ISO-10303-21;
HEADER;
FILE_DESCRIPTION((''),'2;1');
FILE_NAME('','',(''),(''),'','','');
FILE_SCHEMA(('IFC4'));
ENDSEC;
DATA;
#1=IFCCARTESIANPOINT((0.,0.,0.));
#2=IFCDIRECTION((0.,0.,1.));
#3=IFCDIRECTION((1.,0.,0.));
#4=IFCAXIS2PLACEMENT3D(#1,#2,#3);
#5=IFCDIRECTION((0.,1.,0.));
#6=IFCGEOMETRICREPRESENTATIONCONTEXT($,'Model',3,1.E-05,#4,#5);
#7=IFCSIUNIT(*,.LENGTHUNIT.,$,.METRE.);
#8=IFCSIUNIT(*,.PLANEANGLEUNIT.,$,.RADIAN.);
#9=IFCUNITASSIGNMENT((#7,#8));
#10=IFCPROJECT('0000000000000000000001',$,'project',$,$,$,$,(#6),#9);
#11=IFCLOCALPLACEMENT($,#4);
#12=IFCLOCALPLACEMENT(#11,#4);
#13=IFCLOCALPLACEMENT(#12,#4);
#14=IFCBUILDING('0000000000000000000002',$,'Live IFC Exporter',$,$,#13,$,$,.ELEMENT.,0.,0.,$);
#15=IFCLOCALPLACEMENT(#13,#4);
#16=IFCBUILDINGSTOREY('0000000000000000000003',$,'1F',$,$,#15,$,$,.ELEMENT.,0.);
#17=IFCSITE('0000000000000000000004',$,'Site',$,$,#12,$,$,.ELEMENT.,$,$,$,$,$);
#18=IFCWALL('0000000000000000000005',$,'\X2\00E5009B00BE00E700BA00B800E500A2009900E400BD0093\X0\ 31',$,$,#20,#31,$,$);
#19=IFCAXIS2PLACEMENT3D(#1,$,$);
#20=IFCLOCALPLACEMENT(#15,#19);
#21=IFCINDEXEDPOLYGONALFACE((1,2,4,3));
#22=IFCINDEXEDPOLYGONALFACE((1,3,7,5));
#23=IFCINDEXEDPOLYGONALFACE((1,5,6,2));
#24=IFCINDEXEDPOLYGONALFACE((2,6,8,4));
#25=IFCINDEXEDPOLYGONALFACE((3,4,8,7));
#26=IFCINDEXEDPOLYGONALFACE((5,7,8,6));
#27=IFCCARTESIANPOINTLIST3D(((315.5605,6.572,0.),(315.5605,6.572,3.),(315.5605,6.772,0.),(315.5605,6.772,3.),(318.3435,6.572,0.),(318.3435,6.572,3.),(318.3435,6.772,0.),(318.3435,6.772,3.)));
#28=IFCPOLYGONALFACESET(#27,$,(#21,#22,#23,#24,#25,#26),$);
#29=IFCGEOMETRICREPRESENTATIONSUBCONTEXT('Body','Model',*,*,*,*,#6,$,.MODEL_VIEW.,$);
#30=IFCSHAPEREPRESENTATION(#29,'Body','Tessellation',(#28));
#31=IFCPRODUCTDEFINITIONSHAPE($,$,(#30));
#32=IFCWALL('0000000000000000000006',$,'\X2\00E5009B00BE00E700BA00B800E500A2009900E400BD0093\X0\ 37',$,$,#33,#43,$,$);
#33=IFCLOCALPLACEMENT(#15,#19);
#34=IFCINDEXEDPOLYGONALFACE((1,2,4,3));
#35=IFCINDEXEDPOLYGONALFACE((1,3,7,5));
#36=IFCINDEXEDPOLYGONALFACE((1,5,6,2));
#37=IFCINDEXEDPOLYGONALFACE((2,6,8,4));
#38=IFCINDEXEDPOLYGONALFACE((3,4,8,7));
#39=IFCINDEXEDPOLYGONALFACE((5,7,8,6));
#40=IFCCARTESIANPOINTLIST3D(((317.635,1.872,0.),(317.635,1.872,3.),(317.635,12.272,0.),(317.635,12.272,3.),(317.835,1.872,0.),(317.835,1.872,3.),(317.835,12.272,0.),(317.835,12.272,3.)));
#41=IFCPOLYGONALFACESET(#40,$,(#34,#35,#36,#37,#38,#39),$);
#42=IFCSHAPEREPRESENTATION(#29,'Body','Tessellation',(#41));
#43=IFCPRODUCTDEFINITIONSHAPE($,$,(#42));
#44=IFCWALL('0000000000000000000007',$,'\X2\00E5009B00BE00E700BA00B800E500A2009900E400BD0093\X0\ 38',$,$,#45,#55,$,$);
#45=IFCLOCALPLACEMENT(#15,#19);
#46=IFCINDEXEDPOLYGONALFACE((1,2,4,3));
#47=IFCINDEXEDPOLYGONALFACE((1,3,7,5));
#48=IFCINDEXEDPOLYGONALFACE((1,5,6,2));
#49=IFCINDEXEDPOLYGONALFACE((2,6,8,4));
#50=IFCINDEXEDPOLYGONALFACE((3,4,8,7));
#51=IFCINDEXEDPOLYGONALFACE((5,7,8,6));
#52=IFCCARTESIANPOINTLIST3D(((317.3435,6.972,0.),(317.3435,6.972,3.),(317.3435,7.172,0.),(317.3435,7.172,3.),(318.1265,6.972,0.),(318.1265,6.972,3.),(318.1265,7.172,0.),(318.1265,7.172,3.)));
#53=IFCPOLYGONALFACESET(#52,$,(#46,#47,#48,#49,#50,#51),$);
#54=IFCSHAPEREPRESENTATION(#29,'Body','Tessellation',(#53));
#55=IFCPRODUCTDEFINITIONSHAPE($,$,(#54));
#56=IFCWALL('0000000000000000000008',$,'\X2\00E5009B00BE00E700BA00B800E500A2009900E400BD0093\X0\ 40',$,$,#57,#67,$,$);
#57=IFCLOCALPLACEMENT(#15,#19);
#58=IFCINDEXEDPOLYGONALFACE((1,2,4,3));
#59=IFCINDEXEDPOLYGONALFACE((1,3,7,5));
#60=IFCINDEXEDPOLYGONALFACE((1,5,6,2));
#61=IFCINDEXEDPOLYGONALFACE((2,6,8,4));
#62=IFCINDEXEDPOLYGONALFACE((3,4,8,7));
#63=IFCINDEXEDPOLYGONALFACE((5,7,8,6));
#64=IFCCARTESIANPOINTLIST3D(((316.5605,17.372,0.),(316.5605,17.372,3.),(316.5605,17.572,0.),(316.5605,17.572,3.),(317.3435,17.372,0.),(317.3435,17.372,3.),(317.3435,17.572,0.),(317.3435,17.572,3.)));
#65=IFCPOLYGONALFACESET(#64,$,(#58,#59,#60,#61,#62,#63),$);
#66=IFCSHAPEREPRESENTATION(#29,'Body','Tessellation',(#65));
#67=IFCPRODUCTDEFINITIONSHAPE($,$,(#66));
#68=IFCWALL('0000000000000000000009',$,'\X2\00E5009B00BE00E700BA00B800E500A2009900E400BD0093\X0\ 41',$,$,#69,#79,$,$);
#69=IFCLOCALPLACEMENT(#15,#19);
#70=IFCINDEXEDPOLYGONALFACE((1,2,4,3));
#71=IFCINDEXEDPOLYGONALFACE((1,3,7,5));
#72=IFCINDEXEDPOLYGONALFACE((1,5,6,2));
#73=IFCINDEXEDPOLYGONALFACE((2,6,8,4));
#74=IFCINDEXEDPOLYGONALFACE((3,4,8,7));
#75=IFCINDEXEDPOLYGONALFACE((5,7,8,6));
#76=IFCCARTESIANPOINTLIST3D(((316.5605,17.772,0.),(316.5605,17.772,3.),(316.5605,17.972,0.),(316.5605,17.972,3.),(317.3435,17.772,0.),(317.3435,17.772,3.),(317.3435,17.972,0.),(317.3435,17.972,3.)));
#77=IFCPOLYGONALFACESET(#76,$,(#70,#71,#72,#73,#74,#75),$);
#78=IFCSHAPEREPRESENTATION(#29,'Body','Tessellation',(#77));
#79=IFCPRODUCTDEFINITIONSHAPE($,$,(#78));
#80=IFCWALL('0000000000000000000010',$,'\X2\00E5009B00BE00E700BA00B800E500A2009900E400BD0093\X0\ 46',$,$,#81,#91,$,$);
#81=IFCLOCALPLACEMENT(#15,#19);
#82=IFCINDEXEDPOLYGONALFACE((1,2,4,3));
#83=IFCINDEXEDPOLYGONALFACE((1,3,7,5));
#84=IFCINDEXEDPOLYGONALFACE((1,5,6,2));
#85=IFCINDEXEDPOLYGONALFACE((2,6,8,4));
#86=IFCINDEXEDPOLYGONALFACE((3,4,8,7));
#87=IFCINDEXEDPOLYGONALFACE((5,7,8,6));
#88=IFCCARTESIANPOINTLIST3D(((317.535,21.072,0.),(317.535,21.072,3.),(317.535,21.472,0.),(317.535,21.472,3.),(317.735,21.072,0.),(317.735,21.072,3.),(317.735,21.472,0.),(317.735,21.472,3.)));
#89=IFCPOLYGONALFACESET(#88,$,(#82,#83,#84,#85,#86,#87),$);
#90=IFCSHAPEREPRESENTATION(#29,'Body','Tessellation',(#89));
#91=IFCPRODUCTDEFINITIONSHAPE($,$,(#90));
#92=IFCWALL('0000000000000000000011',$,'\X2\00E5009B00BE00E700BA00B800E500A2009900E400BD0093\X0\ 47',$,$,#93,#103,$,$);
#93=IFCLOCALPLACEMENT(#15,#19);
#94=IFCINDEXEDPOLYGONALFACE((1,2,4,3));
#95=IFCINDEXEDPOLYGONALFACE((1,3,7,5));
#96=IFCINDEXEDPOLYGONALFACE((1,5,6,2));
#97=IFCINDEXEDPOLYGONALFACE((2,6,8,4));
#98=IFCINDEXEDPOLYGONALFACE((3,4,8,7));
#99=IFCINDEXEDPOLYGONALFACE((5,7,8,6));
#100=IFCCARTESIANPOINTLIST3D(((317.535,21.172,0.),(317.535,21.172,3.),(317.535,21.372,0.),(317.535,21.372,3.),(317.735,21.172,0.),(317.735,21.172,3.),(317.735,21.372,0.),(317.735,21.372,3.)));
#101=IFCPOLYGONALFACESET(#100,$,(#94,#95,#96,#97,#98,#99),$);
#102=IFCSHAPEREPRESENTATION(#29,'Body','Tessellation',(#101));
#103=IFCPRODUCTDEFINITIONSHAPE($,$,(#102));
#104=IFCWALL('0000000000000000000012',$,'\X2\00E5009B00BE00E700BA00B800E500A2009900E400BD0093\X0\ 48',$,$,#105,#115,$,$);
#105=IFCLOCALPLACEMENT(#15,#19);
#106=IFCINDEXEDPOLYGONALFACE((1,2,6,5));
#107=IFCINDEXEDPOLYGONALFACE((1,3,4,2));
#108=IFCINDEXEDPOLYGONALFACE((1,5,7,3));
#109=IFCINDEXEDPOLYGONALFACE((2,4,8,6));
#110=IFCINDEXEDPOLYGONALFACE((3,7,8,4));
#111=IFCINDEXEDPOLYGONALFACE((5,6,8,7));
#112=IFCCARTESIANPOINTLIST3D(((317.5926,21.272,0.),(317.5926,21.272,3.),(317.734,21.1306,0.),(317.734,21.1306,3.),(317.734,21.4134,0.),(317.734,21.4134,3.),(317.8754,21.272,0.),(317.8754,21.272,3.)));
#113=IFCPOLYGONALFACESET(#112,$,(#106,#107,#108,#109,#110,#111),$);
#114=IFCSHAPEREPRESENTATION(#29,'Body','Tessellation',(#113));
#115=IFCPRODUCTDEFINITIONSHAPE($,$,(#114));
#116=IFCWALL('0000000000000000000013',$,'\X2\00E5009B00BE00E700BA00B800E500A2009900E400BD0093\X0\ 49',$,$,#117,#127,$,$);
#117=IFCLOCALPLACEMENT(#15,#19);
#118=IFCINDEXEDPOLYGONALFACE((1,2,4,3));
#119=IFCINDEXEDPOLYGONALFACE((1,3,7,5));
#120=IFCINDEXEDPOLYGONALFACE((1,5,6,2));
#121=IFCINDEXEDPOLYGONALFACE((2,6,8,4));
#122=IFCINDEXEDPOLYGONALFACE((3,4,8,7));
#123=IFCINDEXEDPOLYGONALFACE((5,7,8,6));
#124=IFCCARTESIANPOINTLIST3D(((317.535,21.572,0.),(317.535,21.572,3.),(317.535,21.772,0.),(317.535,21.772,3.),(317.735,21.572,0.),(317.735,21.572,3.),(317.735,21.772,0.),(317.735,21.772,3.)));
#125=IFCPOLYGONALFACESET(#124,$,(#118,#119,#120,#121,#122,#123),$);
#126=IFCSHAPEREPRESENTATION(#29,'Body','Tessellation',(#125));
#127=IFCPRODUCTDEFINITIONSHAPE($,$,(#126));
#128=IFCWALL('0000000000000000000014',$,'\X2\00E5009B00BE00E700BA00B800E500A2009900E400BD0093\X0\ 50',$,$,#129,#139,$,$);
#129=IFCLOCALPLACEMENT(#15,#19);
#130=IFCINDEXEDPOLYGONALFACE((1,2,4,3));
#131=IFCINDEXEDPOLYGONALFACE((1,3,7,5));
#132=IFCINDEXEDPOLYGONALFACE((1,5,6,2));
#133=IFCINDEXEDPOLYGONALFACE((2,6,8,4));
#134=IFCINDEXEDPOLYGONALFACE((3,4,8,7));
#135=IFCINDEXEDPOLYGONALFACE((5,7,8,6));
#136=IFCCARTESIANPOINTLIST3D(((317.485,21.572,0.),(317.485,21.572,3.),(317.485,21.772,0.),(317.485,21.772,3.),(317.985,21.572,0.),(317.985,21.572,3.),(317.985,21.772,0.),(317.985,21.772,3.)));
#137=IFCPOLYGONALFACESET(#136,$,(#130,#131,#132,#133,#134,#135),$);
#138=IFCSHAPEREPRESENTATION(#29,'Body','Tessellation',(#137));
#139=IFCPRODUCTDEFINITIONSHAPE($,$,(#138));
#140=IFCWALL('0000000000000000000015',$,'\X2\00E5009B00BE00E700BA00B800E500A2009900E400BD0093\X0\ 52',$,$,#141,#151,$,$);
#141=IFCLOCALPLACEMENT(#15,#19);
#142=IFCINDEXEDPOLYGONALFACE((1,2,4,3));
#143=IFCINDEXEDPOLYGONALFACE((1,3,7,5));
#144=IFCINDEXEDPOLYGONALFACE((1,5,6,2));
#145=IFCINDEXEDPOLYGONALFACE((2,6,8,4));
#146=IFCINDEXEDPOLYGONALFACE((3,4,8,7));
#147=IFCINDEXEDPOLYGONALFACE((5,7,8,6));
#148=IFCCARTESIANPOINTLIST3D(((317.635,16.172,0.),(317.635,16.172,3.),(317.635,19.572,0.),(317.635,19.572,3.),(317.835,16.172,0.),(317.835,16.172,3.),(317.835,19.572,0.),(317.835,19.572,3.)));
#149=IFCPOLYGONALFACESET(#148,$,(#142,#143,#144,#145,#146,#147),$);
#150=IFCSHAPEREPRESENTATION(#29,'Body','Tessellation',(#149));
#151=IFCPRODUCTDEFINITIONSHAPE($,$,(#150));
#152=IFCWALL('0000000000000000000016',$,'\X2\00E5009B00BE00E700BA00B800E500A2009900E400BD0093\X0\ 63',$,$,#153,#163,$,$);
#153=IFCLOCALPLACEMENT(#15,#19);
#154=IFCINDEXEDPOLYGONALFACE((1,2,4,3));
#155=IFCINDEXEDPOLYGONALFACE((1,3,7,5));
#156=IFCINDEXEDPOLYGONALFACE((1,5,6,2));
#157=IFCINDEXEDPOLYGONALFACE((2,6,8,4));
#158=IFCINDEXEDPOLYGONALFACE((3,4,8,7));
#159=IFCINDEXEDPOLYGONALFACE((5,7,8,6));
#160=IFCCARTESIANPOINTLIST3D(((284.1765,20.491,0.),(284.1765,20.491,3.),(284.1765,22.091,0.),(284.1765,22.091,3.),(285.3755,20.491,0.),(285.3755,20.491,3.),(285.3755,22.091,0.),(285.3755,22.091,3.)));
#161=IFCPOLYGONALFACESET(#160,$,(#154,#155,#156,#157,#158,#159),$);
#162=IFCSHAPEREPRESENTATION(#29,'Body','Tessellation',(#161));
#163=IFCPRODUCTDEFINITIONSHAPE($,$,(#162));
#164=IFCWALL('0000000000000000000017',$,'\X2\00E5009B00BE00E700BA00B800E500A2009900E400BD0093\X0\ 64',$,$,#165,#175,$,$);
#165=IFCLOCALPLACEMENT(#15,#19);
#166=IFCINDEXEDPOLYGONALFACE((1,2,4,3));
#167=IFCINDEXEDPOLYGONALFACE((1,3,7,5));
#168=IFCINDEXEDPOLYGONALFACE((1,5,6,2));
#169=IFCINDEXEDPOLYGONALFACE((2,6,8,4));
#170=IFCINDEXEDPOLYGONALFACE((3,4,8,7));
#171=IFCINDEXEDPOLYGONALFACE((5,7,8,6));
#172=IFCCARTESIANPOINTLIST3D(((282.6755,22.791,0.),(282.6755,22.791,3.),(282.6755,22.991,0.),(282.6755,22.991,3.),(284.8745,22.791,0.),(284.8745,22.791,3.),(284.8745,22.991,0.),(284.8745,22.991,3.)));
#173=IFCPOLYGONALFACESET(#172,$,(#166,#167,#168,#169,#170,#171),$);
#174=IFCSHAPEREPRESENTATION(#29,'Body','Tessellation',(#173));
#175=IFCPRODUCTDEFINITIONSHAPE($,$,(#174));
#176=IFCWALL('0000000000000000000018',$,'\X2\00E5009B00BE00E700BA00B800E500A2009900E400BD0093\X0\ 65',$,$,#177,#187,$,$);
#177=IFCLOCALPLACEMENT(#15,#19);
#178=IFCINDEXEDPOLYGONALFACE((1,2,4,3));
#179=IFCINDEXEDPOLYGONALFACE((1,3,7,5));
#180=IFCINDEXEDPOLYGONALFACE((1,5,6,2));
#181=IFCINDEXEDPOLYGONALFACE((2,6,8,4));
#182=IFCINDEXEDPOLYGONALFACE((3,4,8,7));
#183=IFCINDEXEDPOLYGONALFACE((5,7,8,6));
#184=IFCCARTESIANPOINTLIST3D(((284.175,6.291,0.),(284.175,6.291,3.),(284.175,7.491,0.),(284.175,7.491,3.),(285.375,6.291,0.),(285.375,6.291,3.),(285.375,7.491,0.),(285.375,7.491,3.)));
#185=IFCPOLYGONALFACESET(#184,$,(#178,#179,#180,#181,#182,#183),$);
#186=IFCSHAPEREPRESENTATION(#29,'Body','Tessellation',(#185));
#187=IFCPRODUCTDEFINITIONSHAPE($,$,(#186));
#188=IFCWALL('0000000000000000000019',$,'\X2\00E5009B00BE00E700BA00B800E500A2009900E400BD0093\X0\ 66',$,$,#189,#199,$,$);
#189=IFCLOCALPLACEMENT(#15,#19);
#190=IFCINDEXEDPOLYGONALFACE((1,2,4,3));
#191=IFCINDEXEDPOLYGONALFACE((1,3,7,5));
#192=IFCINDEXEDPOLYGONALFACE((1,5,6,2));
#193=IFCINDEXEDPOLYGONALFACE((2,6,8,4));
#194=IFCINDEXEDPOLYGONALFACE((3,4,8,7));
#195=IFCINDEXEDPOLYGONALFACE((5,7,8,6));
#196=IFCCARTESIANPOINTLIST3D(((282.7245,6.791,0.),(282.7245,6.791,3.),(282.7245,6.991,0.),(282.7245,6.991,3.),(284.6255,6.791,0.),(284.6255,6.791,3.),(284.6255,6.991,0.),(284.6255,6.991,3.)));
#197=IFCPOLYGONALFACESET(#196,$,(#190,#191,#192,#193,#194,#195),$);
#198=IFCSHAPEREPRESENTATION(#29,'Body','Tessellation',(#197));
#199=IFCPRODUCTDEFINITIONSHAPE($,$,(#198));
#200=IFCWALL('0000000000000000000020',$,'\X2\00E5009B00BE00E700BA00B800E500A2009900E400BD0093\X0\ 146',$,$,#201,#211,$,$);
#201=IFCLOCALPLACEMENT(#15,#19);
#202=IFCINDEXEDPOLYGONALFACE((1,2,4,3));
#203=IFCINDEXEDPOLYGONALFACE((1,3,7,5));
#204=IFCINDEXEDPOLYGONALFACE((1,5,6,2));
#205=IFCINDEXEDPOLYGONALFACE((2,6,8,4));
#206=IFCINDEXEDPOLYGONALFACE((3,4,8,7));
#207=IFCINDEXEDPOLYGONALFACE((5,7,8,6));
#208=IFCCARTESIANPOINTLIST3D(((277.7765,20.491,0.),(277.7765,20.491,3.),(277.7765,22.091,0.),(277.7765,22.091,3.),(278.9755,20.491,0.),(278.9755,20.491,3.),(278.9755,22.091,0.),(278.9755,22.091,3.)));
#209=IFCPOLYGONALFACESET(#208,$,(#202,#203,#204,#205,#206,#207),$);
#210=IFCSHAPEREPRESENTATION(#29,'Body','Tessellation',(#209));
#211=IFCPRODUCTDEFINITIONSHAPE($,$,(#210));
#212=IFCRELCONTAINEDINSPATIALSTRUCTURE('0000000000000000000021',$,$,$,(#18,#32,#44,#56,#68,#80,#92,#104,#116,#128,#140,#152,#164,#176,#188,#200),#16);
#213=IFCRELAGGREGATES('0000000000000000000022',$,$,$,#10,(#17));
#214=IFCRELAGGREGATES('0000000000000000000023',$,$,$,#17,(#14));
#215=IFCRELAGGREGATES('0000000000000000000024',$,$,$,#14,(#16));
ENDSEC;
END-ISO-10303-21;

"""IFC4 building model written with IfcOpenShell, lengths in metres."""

from ifc_helpers import new_model, si_unit, direction, frame, frame_2d, origin_with_axes, place, context, subcontext, project, spatial, rectangle, extrude, element, save


model = new_model("IFC4")

# Units and contexts
model_context = context("Model", 3, precision=1e-05, world=origin_with_axes(), true_north=direction((0.0, 1.0, 0.0)))
body_context = subcontext(model_context, "Body", "Model", "MODEL_VIEW")
ifc_project = project(units=[si_unit("LENGTHUNIT", "METRE"), si_unit("PLANEANGLEUNIT", "RADIAN")], contexts=[model_context])

# Site, building, storey
placement = place(None, origin_with_axes())
site_placement = place(placement, origin_with_axes())
site = spatial("IfcSite", under=ifc_project, at=site_placement, Name="Site", CompositionType="ELEMENT")
building_placement = place(site_placement, origin_with_axes())
building = spatial("IfcBuilding", under=site, at=building_placement, Name="Live IFC Exporter", CompositionType="ELEMENT", ElevationOfRefHeight=0.0, ElevationOfTerrain=0.0)
storey_placement = place(building_placement, origin_with_axes())
storey = spatial("IfcBuildingStorey", under=building, at=storey_placement, Name="1F", CompositionType="ELEMENT", Elevation=0.0)

# Walls
wall_1_placement = place(storey_placement, frame((316.952, 6.672, 0.0), z_axis=(0.0, 0.0, 1.0), x_axis=(1.0, 0.0, 0.0)))
element("IfcWall", 1, at=wall_1_placement, inside=storey, Name="å\u009b¾çº¸å¢\u0099ä½\u0093 31", context=body_context, shape_type="SweptSolid", body=[
    extrude(rectangle(XDim=2.783, YDim=0.2, at=frame_2d((0.0, 0.0), x_axis=(1.0, 0.0, 0.0))), frame((0.0, 0.0, 0.0), z_axis=(0.0, 0.0, 1.0)), (0.0, 0.0, 1.0), 3.0),
])
wall_2_placement = place(storey_placement, frame((317.735, 7.072, 0.0), z_axis=(0.0, 0.0, 1.0), x_axis=(0.0, 1.0, 0.0)))
element("IfcWall", 2, at=wall_2_placement, inside=storey, Name="å\u009b¾çº¸å¢\u0099ä½\u0093 37", context=body_context, shape_type="SweptSolid", body=[
    extrude(rectangle(XDim=10.4, YDim=0.2, at=frame_2d((0.0, 0.0), x_axis=(1.0, 0.0, 0.0))), frame((0.0, 0.0, 0.0), z_axis=(0.0, 0.0, 1.0)), (0.0, 0.0, 1.0), 3.0),
])
for number, where, z_axis, x_axis, name in (
    (3, (317.735, 7.072, 0.0), (0.0, 0.0, 1.0), (-1.0, 0.0, 0.0), "å\u009b¾çº¸å¢\u0099ä½\u0093 38"),
    (4, (316.952, 17.472, 0.0), (0.0, 0.0, 1.0), (1.0, 0.0, 0.0), "å\u009b¾çº¸å¢\u0099ä½\u0093 40"),
    (5, (316.952, 17.872, 0.0), (0.0, 0.0, 1.0), (1.0, 0.0, 0.0), "å\u009b¾çº¸å¢\u0099ä½\u0093 41"),
):
    element("IfcWall", number, at=place(storey_placement, frame(where, z_axis=z_axis, x_axis=x_axis)), inside=storey, Name=name, context=body_context, shape_type="SweptSolid", body=[
        extrude(rectangle(XDim=0.783, YDim=0.2, at=frame_2d((0.0, 0.0), x_axis=(1.0, 0.0, 0.0))), frame((0.0, 0.0, 0.0), z_axis=(0.0, 0.0, 1.0)), (0.0, 0.0, 1.0), 3.0),
    ])
wall_3_placement = place(storey_placement, frame((317.635, 21.272, 0.0), z_axis=(0.0, 0.0, 1.0), x_axis=(0.0, 1.0, 0.0)))
element("IfcWall", 6, at=wall_3_placement, inside=storey, Name="å\u009b¾çº¸å¢\u0099ä½\u0093 46", context=body_context, shape_type="SweptSolid", body=[
    extrude(rectangle(XDim=0.4, YDim=0.2, at=frame_2d((0.0, 0.0), x_axis=(1.0, 0.0, 0.0))), frame((0.0, 0.0, 0.0), z_axis=(0.0, 0.0, 1.0)), (0.0, 0.0, 1.0), 3.0),
])
for number, where, z_axis, x_axis, name in (
    (7, (317.635, 21.272, 0.0), (0.0, 0.0, 1.0), (1.0, 0.0, 0.0), "å\u009b¾çº¸å¢\u0099ä½\u0093 47"),
    (8, (317.734, 21.272, 0.0), (0.0, 0.0, 1.0), (0.707107, -0.707107, 0.0), "å\u009b¾çº¸å¢\u0099ä½\u0093 48"),
    (9, (317.635, 21.672, 0.0), (0.0, 0.0, 1.0), (1.0, 0.0, 0.0), "å\u009b¾çº¸å¢\u0099ä½\u0093 49"),
):
    element("IfcWall", number, at=place(storey_placement, frame(where, z_axis=z_axis, x_axis=x_axis)), inside=storey, Name=name, context=body_context, shape_type="SweptSolid", body=[
        extrude(rectangle(XDim=0.2, YDim=0.2, at=frame_2d((0.0, 0.0), x_axis=(1.0, 0.0, 0.0))), frame((0.0, 0.0, 0.0), z_axis=(0.0, 0.0, 1.0)), (0.0, 0.0, 1.0), 3.0),
    ])
wall_4_placement = place(storey_placement, frame((317.735, 21.672, 0.0), z_axis=(0.0, 0.0, 1.0), x_axis=(1.0, 0.0, 0.0)))
element("IfcWall", 10, at=wall_4_placement, inside=storey, Name="å\u009b¾çº¸å¢\u0099ä½\u0093 50", context=body_context, shape_type="SweptSolid", body=[
    extrude(rectangle(XDim=0.5, YDim=0.2, at=frame_2d((0.0, 0.0), x_axis=(1.0, 0.0, 0.0))), frame((0.0, 0.0, 0.0), z_axis=(0.0, 0.0, 1.0)), (0.0, 0.0, 1.0), 3.0),
])
wall_5_placement = place(storey_placement, frame((317.735, 17.872, 0.0), z_axis=(0.0, 0.0, 1.0), x_axis=(0.0, 1.0, 0.0)))
element("IfcWall", 11, at=wall_5_placement, inside=storey, Name="å\u009b¾çº¸å¢\u0099ä½\u0093 52", context=body_context, shape_type="SweptSolid", body=[
    extrude(rectangle(XDim=3.4, YDim=0.2, at=frame_2d((0.0, 0.0), x_axis=(1.0, 0.0, 0.0))), frame((0.0, 0.0, 0.0), z_axis=(0.0, 0.0, 1.0)), (0.0, 0.0, 1.0), 3.0),
])
wall_6_placement = place(storey_placement, frame((284.776, 21.291, 0.0), z_axis=(0.0, 0.0, 1.0), x_axis=(1.0, 0.0, 0.0)))
element("IfcWall", 12, at=wall_6_placement, inside=storey, Name="å\u009b¾çº¸å¢\u0099ä½\u0093 63", context=body_context, shape_type="SweptSolid", body=[
    extrude(rectangle(XDim=1.199, YDim=1.6, at=frame_2d((0.0, 0.0), x_axis=(1.0, 0.0, 0.0))), frame((0.0, 0.0, 0.0), z_axis=(0.0, 0.0, 1.0)), (0.0, 0.0, 1.0), 3.0),
])
wall_7_placement = place(storey_placement, frame((283.775, 22.891, 0.0), z_axis=(0.0, 0.0, 1.0), x_axis=(1.0, 0.0, 0.0)))
element("IfcWall", 13, at=wall_7_placement, inside=storey, Name="å\u009b¾çº¸å¢\u0099ä½\u0093 64", context=body_context, shape_type="SweptSolid", body=[
    extrude(rectangle(XDim=2.199, YDim=0.2, at=frame_2d((0.0, 0.0), x_axis=(1.0, 0.0, 0.0))), frame((0.0, 0.0, 0.0), z_axis=(0.0, 0.0, 1.0)), (0.0, 0.0, 1.0), 3.0),
])
wall_8_placement = place(storey_placement, frame((284.775, 6.891, 0.0), z_axis=(0.0, 0.0, 1.0), x_axis=(1.0, 0.0, 0.0)))
element("IfcWall", 14, at=wall_8_placement, inside=storey, Name="å\u009b¾çº¸å¢\u0099ä½\u0093 65", context=body_context, shape_type="SweptSolid", body=[
    extrude(rectangle(XDim=1.2, YDim=1.2, at=frame_2d((0.0, 0.0), x_axis=(1.0, 0.0, 0.0))), frame((0.0, 0.0, 0.0), z_axis=(0.0, 0.0, 1.0)), (0.0, 0.0, 1.0), 3.0),
])
wall_9_placement = place(storey_placement, frame((283.675, 6.891, 0.0), z_axis=(0.0, 0.0, 1.0), x_axis=(1.0, 0.0, 0.0)))
element("IfcWall", 15, at=wall_9_placement, inside=storey, Name="å\u009b¾çº¸å¢\u0099ä½\u0093 66", context=body_context, shape_type="SweptSolid", body=[
    extrude(rectangle(XDim=1.901, YDim=0.2, at=frame_2d((0.0, 0.0), x_axis=(1.0, 0.0, 0.0))), frame((0.0, 0.0, 0.0), z_axis=(0.0, 0.0, 1.0)), (0.0, 0.0, 1.0), 3.0),
])
wall_10_placement = place(storey_placement, frame((278.376, 21.291, 0.0), z_axis=(0.0, 0.0, 1.0), x_axis=(1.0, 0.0, 0.0)))
element("IfcWall", 16, at=wall_10_placement, inside=storey, Name="å\u009b¾çº¸å¢\u0099ä½\u0093 146", context=body_context, shape_type="SweptSolid", body=[
    extrude(rectangle(XDim=1.199, YDim=1.6, at=frame_2d((0.0, 0.0), x_axis=(1.0, 0.0, 0.0))), frame((0.0, 0.0, 0.0), z_axis=(0.0, 0.0, 1.0)), (0.0, 0.0, 1.0), 3.0),
])

save(model, "model.ifc")
